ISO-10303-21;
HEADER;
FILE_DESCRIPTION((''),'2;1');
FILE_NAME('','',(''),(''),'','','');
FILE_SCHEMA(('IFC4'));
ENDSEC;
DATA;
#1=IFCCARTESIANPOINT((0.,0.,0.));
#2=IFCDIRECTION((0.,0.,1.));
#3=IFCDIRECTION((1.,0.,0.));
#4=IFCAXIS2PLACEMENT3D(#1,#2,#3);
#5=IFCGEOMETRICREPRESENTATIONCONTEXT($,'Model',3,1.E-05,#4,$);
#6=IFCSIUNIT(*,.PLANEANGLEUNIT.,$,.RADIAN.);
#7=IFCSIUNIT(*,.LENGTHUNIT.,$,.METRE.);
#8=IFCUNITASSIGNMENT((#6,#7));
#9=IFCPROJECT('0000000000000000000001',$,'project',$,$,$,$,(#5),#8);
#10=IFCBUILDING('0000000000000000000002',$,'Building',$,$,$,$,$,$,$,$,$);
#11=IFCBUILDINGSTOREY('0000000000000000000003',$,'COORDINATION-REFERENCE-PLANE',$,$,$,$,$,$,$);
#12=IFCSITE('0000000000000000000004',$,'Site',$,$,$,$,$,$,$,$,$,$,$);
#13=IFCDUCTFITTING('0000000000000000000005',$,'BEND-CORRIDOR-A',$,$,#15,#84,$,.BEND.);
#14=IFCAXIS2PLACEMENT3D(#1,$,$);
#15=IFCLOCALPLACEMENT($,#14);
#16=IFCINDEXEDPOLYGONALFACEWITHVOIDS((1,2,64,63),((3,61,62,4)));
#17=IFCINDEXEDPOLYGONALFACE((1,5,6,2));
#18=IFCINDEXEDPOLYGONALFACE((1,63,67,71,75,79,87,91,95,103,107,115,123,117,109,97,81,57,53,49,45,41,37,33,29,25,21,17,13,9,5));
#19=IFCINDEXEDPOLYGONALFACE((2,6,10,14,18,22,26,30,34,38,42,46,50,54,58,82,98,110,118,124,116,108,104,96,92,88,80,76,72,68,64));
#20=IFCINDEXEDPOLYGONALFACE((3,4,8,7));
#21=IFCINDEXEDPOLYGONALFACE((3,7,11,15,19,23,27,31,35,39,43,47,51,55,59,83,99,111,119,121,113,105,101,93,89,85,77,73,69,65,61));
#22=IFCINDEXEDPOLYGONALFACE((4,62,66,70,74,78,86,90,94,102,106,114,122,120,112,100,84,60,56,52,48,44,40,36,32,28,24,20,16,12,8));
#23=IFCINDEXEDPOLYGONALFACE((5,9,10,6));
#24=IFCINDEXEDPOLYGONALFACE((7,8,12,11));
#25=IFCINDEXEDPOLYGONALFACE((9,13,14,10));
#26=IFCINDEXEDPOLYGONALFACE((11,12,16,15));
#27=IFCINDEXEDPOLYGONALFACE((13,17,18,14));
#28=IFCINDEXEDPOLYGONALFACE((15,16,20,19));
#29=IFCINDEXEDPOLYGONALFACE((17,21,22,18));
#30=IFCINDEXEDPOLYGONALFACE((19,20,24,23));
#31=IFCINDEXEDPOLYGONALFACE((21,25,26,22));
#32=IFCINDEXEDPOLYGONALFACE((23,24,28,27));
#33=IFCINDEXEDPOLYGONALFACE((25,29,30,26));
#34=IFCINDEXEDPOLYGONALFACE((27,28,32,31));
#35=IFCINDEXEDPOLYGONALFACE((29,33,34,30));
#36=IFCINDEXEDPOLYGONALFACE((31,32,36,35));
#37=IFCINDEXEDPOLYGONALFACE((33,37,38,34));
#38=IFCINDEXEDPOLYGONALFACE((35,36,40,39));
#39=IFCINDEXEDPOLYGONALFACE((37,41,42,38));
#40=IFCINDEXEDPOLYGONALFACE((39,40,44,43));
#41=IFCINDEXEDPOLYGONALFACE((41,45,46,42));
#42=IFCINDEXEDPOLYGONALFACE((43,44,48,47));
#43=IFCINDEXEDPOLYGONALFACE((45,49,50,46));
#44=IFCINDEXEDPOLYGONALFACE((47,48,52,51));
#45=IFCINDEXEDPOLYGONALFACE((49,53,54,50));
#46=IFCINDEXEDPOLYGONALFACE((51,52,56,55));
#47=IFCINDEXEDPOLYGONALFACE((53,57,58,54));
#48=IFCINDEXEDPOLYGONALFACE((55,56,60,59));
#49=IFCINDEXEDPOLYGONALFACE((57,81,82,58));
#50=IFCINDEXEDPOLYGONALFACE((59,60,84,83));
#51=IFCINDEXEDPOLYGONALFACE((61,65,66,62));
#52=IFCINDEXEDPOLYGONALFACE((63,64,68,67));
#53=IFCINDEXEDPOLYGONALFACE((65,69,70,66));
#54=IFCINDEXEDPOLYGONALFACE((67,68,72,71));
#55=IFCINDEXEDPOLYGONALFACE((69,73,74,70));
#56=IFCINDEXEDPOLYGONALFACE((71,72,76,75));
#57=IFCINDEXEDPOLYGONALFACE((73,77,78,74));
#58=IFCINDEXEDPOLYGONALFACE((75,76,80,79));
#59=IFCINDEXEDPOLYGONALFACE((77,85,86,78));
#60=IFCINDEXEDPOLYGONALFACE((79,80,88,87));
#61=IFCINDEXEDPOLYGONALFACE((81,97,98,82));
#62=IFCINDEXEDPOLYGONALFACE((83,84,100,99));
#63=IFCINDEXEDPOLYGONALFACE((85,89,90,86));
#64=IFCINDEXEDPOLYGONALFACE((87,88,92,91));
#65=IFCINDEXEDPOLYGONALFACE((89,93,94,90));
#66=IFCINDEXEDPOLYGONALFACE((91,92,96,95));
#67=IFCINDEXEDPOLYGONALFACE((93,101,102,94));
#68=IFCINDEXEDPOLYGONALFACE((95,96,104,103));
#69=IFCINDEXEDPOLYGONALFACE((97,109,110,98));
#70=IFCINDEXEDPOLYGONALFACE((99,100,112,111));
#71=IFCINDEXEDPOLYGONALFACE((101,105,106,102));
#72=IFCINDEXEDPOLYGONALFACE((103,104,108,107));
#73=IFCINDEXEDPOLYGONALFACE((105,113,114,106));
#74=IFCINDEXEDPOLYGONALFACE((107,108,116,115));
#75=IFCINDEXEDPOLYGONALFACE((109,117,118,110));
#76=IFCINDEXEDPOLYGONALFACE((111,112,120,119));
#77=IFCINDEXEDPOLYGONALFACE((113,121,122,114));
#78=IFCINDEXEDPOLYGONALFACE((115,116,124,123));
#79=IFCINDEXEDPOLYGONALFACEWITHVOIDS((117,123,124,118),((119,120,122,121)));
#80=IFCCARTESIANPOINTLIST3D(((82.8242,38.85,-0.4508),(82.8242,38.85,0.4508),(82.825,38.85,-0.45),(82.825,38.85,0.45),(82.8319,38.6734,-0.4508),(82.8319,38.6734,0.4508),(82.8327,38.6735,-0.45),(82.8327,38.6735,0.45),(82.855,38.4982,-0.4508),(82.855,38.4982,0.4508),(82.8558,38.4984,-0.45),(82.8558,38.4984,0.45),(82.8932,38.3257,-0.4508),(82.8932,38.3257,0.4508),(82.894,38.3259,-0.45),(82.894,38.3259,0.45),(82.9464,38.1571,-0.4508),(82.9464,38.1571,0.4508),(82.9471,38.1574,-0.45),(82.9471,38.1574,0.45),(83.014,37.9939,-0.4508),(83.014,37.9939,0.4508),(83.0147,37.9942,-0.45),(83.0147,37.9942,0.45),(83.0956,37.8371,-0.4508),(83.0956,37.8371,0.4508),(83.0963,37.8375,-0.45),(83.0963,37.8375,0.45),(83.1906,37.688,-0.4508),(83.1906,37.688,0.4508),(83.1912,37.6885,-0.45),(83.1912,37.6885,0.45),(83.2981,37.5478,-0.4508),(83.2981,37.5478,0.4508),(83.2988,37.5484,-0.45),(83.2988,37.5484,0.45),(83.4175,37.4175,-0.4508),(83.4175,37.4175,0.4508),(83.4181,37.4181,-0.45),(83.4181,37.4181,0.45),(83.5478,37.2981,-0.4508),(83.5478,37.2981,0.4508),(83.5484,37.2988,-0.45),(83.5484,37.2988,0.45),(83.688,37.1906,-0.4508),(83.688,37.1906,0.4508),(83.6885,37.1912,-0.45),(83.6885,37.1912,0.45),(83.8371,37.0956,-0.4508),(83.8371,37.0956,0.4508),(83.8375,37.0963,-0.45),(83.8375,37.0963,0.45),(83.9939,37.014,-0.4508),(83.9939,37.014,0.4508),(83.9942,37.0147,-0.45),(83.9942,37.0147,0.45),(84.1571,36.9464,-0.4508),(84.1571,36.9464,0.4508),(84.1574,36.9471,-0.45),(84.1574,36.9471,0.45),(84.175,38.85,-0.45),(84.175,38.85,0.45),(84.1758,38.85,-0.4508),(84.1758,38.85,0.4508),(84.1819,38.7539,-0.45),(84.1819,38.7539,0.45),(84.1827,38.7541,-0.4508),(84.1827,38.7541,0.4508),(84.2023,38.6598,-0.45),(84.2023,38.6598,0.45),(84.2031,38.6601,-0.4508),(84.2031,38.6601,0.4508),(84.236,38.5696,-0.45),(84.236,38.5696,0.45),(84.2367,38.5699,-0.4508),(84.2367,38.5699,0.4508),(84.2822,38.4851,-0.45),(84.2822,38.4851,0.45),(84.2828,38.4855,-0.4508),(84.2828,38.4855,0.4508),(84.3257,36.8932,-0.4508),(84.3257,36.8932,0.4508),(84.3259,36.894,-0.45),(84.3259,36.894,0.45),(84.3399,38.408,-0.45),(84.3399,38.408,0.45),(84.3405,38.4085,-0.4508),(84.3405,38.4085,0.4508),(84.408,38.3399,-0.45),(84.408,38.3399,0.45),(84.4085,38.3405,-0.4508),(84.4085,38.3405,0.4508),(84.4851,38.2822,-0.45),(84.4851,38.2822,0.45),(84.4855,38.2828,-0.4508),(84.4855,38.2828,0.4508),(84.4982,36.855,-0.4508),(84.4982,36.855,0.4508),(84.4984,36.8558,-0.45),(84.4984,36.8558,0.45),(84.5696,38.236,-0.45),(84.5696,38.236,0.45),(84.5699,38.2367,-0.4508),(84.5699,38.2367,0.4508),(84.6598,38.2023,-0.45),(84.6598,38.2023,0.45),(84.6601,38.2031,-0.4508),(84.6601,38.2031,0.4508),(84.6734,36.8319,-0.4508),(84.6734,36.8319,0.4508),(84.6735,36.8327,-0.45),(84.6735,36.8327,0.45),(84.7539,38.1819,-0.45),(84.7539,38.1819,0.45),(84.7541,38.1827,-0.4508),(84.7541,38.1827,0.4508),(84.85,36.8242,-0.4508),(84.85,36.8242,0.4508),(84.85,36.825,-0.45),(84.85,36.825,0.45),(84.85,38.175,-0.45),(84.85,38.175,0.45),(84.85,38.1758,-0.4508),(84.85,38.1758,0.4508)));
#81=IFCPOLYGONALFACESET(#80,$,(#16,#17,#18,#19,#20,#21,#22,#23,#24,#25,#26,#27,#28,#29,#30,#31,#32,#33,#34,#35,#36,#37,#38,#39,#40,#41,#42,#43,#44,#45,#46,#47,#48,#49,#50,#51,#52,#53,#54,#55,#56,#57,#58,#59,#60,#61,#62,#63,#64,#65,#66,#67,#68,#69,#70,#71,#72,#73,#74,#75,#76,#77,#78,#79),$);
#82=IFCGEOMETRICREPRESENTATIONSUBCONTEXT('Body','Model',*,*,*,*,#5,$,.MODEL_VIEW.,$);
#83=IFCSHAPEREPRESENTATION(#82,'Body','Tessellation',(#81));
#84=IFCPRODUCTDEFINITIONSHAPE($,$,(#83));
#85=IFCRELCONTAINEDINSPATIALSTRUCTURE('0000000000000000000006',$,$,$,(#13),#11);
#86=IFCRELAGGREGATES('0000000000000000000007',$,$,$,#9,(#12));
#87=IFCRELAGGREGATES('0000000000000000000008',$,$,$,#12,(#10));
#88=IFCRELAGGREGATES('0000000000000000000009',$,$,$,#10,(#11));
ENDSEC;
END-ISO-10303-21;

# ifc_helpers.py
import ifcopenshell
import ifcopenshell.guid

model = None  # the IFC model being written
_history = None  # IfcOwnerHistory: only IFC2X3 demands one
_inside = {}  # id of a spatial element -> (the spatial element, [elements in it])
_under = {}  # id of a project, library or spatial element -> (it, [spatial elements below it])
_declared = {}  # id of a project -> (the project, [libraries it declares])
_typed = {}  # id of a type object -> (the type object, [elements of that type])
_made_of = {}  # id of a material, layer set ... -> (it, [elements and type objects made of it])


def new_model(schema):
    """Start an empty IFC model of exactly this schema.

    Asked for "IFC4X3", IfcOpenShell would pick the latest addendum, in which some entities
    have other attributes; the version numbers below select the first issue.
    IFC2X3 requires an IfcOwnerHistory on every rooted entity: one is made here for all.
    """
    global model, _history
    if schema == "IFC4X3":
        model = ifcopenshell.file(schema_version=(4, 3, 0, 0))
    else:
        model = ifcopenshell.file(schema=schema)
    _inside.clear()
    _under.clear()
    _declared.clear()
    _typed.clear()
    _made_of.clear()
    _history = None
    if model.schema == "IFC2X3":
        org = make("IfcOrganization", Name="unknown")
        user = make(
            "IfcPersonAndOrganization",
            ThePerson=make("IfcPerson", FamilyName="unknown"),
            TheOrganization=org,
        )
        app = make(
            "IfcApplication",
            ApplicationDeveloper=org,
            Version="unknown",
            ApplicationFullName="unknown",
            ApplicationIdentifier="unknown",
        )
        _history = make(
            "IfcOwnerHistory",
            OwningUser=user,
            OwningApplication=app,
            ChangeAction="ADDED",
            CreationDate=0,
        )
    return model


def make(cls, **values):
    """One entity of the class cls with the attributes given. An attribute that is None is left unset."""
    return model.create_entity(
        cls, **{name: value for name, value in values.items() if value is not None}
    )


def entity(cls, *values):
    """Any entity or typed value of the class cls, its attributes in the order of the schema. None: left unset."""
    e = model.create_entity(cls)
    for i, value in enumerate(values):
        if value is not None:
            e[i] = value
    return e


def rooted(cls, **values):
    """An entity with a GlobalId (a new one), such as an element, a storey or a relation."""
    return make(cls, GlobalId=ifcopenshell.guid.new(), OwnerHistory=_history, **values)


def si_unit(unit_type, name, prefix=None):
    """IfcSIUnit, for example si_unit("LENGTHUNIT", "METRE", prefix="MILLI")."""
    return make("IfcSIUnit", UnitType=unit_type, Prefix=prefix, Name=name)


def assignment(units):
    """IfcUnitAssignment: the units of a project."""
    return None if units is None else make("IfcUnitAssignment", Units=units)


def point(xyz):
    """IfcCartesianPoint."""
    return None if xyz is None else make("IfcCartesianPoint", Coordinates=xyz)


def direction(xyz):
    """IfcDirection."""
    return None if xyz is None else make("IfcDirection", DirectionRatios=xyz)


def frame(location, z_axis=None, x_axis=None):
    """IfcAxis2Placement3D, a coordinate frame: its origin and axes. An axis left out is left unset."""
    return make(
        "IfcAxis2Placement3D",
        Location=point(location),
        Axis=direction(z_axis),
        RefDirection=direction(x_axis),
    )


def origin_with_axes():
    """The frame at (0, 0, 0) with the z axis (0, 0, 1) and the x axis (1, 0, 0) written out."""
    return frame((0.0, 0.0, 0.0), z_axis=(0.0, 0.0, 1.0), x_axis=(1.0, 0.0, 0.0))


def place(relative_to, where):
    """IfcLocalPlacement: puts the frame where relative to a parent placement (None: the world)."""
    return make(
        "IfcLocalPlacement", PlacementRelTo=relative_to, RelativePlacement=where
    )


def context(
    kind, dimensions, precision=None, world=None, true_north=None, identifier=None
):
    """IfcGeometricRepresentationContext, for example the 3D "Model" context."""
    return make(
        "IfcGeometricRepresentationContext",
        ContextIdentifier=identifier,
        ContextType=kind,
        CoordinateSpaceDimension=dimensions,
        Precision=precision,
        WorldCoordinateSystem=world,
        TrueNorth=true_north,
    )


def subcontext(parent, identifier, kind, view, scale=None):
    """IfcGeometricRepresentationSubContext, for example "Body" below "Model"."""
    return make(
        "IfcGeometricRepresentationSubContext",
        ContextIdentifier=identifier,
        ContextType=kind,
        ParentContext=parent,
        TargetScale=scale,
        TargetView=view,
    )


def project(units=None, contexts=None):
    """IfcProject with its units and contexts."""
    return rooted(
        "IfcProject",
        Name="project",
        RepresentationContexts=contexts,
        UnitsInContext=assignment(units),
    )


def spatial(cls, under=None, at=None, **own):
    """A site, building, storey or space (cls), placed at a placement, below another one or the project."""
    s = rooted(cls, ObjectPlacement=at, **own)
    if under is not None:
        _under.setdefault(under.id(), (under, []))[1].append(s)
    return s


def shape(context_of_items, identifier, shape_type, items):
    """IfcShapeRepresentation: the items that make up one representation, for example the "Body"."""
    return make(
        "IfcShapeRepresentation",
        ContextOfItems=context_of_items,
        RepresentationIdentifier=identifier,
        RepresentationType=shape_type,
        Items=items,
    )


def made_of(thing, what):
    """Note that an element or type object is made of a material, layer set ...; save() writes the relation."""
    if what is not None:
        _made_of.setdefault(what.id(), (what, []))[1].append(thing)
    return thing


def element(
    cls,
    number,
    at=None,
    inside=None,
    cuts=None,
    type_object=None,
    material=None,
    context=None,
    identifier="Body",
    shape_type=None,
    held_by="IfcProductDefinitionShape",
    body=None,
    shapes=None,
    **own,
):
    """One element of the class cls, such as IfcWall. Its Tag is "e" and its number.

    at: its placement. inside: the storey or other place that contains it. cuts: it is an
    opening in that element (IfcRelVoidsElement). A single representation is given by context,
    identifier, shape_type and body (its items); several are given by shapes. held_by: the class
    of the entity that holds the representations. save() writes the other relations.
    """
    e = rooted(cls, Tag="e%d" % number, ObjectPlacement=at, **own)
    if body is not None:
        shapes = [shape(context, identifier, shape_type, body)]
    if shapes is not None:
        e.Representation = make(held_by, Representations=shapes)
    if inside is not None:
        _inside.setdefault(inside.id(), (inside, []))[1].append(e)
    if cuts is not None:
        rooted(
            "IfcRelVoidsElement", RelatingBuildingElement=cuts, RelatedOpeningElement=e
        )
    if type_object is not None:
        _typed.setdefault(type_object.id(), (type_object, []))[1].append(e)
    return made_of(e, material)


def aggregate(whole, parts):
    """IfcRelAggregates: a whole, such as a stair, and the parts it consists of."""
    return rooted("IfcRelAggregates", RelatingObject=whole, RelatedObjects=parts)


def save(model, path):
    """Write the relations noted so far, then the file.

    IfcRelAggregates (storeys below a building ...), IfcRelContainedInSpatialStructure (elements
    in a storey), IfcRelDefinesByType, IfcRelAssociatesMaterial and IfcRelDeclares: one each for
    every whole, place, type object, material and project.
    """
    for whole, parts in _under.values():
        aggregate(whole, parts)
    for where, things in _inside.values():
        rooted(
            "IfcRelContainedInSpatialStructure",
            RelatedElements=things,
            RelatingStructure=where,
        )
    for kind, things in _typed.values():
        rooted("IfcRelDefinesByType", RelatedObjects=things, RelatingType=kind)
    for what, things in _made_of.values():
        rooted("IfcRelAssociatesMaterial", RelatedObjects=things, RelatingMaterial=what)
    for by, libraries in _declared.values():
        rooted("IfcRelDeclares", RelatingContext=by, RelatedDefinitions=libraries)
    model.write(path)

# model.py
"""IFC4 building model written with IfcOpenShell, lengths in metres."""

from ifc_helpers import new_model, entity, si_unit, frame, origin_with_axes, place, context, subcontext, project, spatial, element, save


model = new_model("IFC4")

# Units and contexts
model_context = context("Model", 3, precision=1e-05, world=origin_with_axes())
body_context = subcontext(model_context, "Body", "Model", "MODEL_VIEW")
ifc_project = project(units=[si_unit("PLANEANGLEUNIT", "RADIAN"), si_unit("LENGTHUNIT", "METRE")], contexts=[model_context])

# Site, building, storey
site = spatial("IfcSite", under=ifc_project, Name="Site")
building = spatial("IfcBuilding", under=site, Name="Building")
storey = spatial("IfcBuildingStorey", under=building, Name="COORDINATION-REFERENCE-PLANE")

# Duct fitting
duct_fitting_1_placement = place(None, frame((84.85, 38.85, 0.0), z_axis=(0.0, 0.0, 1.0), x_axis=(-1.0, 0.0, 0.0)))
cartesian_point_1 = entity("IfcCartesianPoint", [0.0, 0.0, 0.0])
element("IfcDuctFitting", 1, at=duct_fitting_1_placement, inside=storey, Name="BEND-CORRIDOR-A", PredefinedType="BEND", context=body_context, shape_type="SweptSolid", body=[
    entity("IfcRevolvedAreaSolid", entity("IfcRectangleHollowProfileDef", "AREA", None, entity("IfcAxis2Placement2D", entity("IfcCartesianPoint", [1.35, 0.0])), 1.3516, 0.9016, 0.0008), entity("IfcAxis2Placement3D", cartesian_point_1, entity("IfcDirection", [0.0, -1.0, 0.0]), entity("IfcDirection", [1.0, 0.0, 0.0])), entity("IfcAxis1Placement", cartesian_point_1, entity("IfcDirection", [0.0, 1.0, 0.0])), 1.570796),
])

save(model, "model.ifc")
